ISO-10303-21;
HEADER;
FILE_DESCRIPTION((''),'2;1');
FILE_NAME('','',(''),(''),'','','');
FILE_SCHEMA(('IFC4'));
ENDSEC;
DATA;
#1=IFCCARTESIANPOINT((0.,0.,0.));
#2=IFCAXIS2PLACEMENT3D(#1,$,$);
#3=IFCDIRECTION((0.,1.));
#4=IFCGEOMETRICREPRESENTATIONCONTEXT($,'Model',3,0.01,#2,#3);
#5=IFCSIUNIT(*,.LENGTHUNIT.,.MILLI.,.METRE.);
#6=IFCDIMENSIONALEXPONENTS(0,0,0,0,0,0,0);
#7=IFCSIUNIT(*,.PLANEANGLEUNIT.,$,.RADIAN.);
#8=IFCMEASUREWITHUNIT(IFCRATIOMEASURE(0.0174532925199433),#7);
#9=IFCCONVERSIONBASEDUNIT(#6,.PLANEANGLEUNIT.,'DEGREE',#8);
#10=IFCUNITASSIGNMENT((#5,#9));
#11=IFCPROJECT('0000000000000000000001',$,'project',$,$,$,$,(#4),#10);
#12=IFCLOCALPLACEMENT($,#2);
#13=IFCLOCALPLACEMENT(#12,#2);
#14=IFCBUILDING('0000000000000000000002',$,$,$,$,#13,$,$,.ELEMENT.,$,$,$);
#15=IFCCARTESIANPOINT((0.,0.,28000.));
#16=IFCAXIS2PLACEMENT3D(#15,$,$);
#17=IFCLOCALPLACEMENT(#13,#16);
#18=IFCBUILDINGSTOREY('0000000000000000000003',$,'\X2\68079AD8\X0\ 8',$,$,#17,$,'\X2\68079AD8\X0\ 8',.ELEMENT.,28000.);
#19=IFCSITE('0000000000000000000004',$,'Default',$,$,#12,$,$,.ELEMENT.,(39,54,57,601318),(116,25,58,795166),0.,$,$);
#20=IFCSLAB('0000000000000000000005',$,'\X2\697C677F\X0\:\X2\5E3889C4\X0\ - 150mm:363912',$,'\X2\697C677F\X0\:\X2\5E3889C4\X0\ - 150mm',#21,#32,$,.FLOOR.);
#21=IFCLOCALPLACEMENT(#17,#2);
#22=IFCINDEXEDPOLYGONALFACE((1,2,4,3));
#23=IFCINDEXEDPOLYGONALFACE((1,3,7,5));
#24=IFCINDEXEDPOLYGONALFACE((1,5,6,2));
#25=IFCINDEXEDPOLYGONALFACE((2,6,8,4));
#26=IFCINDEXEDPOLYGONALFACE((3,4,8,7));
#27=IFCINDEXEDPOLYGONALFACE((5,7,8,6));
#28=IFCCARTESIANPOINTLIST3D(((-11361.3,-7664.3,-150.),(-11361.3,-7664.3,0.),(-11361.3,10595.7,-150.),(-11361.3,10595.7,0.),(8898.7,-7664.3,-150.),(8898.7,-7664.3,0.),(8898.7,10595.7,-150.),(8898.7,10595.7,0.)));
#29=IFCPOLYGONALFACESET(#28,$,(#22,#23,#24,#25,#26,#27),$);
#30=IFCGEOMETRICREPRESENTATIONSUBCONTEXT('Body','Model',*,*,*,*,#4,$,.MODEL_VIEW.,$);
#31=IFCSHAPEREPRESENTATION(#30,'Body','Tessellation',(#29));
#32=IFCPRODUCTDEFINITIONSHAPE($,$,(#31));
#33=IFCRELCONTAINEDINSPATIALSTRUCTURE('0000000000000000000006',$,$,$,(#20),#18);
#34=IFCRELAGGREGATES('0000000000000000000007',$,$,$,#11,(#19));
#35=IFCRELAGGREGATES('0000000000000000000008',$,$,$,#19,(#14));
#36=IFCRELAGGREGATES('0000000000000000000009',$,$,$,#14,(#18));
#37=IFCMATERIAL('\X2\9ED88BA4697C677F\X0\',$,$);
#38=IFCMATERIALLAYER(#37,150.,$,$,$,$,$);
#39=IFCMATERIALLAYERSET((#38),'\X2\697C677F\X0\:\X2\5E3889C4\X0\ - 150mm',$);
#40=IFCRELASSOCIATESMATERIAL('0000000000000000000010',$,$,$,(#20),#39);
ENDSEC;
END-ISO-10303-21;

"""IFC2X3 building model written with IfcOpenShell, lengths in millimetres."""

from ifc_helpers import new_model, entity, si_unit, converted_unit, direction, frame, frame_2d, origin, place, context, subcontext, project, spatial, rectangle, extrude, material, layer, layer_set, layer_usage, element, save


model = new_model("IFC2X3")

# Units and contexts
model_context = context("Model", 3, precision=0.01, world=origin(), true_north=direction((0.0, 1.0)))
body_context = subcontext(model_context, "Body", "Model", "MODEL_VIEW")
ifc_project = project(units=[si_unit("LENGTHUNIT", "METRE", prefix="MILLI"), converted_unit("PLANEANGLEUNIT", "DEGREE", entity("IfcRatioMeasure", 0.0174532925199433), si_unit("PLANEANGLEUNIT", "RADIAN"), dimensions=[0, 0, 0, 0, 0, 0, 0])], contexts=[model_context])

# Site, building, storey
site_placement = place(None, origin())
site = spatial("IfcSite", under=ifc_project, at=site_placement, Name="Default", CompositionType="ELEMENT", RefLatitude=(39, 54, 57, 601318), RefLongitude=(116, 25, 58, 795166), RefElevation=0.0)
building_placement = place(site_placement, origin())
building = spatial("IfcBuilding", under=site, at=building_placement, CompositionType="ELEMENT")
storey_placement = place(building_placement, frame((0.0, 0.0, 28000.0)))
storey = spatial("IfcBuildingStorey", under=building, at=storey_placement, Name="标高 8", LongName="标高 8", CompositionType="ELEMENT", Elevation=28000.0)

# Slab
ifc_material_1 = material(Name="默认楼板")
ifc_layer = layer(ifc_material_1, 150.0)
ifc_layer_set = layer_set([ifc_layer], Name="楼板:常规 - 150mm")
ifc_layer_usage = layer_usage(ifc_layer_set, "AXIS3", "POSITIVE", 0.0)
slab_placement = place(storey_placement, origin())
element("IfcSlab", 1, at=slab_placement, inside=storey, material=ifc_layer_usage, Name="楼板:常规 - 150mm:363912", ObjectType="楼板:常规 - 150mm", PredefinedType="FLOOR", context=body_context, shape_type="SweptSolid", body=[
    extrude(rectangle(XDim=18260.0, YDim=20260.0, at=frame_2d((0.0, 0.0), x_axis=(1.0, 0.0))), frame((-1231.3, 1465.7, 0.0), z_axis=(0.0, 0.0, -1.0), x_axis=(0.0, 1.0, 0.0)), (0.0, 0.0, 1.0), 150.0),
])

save(model, "model.ifc")
